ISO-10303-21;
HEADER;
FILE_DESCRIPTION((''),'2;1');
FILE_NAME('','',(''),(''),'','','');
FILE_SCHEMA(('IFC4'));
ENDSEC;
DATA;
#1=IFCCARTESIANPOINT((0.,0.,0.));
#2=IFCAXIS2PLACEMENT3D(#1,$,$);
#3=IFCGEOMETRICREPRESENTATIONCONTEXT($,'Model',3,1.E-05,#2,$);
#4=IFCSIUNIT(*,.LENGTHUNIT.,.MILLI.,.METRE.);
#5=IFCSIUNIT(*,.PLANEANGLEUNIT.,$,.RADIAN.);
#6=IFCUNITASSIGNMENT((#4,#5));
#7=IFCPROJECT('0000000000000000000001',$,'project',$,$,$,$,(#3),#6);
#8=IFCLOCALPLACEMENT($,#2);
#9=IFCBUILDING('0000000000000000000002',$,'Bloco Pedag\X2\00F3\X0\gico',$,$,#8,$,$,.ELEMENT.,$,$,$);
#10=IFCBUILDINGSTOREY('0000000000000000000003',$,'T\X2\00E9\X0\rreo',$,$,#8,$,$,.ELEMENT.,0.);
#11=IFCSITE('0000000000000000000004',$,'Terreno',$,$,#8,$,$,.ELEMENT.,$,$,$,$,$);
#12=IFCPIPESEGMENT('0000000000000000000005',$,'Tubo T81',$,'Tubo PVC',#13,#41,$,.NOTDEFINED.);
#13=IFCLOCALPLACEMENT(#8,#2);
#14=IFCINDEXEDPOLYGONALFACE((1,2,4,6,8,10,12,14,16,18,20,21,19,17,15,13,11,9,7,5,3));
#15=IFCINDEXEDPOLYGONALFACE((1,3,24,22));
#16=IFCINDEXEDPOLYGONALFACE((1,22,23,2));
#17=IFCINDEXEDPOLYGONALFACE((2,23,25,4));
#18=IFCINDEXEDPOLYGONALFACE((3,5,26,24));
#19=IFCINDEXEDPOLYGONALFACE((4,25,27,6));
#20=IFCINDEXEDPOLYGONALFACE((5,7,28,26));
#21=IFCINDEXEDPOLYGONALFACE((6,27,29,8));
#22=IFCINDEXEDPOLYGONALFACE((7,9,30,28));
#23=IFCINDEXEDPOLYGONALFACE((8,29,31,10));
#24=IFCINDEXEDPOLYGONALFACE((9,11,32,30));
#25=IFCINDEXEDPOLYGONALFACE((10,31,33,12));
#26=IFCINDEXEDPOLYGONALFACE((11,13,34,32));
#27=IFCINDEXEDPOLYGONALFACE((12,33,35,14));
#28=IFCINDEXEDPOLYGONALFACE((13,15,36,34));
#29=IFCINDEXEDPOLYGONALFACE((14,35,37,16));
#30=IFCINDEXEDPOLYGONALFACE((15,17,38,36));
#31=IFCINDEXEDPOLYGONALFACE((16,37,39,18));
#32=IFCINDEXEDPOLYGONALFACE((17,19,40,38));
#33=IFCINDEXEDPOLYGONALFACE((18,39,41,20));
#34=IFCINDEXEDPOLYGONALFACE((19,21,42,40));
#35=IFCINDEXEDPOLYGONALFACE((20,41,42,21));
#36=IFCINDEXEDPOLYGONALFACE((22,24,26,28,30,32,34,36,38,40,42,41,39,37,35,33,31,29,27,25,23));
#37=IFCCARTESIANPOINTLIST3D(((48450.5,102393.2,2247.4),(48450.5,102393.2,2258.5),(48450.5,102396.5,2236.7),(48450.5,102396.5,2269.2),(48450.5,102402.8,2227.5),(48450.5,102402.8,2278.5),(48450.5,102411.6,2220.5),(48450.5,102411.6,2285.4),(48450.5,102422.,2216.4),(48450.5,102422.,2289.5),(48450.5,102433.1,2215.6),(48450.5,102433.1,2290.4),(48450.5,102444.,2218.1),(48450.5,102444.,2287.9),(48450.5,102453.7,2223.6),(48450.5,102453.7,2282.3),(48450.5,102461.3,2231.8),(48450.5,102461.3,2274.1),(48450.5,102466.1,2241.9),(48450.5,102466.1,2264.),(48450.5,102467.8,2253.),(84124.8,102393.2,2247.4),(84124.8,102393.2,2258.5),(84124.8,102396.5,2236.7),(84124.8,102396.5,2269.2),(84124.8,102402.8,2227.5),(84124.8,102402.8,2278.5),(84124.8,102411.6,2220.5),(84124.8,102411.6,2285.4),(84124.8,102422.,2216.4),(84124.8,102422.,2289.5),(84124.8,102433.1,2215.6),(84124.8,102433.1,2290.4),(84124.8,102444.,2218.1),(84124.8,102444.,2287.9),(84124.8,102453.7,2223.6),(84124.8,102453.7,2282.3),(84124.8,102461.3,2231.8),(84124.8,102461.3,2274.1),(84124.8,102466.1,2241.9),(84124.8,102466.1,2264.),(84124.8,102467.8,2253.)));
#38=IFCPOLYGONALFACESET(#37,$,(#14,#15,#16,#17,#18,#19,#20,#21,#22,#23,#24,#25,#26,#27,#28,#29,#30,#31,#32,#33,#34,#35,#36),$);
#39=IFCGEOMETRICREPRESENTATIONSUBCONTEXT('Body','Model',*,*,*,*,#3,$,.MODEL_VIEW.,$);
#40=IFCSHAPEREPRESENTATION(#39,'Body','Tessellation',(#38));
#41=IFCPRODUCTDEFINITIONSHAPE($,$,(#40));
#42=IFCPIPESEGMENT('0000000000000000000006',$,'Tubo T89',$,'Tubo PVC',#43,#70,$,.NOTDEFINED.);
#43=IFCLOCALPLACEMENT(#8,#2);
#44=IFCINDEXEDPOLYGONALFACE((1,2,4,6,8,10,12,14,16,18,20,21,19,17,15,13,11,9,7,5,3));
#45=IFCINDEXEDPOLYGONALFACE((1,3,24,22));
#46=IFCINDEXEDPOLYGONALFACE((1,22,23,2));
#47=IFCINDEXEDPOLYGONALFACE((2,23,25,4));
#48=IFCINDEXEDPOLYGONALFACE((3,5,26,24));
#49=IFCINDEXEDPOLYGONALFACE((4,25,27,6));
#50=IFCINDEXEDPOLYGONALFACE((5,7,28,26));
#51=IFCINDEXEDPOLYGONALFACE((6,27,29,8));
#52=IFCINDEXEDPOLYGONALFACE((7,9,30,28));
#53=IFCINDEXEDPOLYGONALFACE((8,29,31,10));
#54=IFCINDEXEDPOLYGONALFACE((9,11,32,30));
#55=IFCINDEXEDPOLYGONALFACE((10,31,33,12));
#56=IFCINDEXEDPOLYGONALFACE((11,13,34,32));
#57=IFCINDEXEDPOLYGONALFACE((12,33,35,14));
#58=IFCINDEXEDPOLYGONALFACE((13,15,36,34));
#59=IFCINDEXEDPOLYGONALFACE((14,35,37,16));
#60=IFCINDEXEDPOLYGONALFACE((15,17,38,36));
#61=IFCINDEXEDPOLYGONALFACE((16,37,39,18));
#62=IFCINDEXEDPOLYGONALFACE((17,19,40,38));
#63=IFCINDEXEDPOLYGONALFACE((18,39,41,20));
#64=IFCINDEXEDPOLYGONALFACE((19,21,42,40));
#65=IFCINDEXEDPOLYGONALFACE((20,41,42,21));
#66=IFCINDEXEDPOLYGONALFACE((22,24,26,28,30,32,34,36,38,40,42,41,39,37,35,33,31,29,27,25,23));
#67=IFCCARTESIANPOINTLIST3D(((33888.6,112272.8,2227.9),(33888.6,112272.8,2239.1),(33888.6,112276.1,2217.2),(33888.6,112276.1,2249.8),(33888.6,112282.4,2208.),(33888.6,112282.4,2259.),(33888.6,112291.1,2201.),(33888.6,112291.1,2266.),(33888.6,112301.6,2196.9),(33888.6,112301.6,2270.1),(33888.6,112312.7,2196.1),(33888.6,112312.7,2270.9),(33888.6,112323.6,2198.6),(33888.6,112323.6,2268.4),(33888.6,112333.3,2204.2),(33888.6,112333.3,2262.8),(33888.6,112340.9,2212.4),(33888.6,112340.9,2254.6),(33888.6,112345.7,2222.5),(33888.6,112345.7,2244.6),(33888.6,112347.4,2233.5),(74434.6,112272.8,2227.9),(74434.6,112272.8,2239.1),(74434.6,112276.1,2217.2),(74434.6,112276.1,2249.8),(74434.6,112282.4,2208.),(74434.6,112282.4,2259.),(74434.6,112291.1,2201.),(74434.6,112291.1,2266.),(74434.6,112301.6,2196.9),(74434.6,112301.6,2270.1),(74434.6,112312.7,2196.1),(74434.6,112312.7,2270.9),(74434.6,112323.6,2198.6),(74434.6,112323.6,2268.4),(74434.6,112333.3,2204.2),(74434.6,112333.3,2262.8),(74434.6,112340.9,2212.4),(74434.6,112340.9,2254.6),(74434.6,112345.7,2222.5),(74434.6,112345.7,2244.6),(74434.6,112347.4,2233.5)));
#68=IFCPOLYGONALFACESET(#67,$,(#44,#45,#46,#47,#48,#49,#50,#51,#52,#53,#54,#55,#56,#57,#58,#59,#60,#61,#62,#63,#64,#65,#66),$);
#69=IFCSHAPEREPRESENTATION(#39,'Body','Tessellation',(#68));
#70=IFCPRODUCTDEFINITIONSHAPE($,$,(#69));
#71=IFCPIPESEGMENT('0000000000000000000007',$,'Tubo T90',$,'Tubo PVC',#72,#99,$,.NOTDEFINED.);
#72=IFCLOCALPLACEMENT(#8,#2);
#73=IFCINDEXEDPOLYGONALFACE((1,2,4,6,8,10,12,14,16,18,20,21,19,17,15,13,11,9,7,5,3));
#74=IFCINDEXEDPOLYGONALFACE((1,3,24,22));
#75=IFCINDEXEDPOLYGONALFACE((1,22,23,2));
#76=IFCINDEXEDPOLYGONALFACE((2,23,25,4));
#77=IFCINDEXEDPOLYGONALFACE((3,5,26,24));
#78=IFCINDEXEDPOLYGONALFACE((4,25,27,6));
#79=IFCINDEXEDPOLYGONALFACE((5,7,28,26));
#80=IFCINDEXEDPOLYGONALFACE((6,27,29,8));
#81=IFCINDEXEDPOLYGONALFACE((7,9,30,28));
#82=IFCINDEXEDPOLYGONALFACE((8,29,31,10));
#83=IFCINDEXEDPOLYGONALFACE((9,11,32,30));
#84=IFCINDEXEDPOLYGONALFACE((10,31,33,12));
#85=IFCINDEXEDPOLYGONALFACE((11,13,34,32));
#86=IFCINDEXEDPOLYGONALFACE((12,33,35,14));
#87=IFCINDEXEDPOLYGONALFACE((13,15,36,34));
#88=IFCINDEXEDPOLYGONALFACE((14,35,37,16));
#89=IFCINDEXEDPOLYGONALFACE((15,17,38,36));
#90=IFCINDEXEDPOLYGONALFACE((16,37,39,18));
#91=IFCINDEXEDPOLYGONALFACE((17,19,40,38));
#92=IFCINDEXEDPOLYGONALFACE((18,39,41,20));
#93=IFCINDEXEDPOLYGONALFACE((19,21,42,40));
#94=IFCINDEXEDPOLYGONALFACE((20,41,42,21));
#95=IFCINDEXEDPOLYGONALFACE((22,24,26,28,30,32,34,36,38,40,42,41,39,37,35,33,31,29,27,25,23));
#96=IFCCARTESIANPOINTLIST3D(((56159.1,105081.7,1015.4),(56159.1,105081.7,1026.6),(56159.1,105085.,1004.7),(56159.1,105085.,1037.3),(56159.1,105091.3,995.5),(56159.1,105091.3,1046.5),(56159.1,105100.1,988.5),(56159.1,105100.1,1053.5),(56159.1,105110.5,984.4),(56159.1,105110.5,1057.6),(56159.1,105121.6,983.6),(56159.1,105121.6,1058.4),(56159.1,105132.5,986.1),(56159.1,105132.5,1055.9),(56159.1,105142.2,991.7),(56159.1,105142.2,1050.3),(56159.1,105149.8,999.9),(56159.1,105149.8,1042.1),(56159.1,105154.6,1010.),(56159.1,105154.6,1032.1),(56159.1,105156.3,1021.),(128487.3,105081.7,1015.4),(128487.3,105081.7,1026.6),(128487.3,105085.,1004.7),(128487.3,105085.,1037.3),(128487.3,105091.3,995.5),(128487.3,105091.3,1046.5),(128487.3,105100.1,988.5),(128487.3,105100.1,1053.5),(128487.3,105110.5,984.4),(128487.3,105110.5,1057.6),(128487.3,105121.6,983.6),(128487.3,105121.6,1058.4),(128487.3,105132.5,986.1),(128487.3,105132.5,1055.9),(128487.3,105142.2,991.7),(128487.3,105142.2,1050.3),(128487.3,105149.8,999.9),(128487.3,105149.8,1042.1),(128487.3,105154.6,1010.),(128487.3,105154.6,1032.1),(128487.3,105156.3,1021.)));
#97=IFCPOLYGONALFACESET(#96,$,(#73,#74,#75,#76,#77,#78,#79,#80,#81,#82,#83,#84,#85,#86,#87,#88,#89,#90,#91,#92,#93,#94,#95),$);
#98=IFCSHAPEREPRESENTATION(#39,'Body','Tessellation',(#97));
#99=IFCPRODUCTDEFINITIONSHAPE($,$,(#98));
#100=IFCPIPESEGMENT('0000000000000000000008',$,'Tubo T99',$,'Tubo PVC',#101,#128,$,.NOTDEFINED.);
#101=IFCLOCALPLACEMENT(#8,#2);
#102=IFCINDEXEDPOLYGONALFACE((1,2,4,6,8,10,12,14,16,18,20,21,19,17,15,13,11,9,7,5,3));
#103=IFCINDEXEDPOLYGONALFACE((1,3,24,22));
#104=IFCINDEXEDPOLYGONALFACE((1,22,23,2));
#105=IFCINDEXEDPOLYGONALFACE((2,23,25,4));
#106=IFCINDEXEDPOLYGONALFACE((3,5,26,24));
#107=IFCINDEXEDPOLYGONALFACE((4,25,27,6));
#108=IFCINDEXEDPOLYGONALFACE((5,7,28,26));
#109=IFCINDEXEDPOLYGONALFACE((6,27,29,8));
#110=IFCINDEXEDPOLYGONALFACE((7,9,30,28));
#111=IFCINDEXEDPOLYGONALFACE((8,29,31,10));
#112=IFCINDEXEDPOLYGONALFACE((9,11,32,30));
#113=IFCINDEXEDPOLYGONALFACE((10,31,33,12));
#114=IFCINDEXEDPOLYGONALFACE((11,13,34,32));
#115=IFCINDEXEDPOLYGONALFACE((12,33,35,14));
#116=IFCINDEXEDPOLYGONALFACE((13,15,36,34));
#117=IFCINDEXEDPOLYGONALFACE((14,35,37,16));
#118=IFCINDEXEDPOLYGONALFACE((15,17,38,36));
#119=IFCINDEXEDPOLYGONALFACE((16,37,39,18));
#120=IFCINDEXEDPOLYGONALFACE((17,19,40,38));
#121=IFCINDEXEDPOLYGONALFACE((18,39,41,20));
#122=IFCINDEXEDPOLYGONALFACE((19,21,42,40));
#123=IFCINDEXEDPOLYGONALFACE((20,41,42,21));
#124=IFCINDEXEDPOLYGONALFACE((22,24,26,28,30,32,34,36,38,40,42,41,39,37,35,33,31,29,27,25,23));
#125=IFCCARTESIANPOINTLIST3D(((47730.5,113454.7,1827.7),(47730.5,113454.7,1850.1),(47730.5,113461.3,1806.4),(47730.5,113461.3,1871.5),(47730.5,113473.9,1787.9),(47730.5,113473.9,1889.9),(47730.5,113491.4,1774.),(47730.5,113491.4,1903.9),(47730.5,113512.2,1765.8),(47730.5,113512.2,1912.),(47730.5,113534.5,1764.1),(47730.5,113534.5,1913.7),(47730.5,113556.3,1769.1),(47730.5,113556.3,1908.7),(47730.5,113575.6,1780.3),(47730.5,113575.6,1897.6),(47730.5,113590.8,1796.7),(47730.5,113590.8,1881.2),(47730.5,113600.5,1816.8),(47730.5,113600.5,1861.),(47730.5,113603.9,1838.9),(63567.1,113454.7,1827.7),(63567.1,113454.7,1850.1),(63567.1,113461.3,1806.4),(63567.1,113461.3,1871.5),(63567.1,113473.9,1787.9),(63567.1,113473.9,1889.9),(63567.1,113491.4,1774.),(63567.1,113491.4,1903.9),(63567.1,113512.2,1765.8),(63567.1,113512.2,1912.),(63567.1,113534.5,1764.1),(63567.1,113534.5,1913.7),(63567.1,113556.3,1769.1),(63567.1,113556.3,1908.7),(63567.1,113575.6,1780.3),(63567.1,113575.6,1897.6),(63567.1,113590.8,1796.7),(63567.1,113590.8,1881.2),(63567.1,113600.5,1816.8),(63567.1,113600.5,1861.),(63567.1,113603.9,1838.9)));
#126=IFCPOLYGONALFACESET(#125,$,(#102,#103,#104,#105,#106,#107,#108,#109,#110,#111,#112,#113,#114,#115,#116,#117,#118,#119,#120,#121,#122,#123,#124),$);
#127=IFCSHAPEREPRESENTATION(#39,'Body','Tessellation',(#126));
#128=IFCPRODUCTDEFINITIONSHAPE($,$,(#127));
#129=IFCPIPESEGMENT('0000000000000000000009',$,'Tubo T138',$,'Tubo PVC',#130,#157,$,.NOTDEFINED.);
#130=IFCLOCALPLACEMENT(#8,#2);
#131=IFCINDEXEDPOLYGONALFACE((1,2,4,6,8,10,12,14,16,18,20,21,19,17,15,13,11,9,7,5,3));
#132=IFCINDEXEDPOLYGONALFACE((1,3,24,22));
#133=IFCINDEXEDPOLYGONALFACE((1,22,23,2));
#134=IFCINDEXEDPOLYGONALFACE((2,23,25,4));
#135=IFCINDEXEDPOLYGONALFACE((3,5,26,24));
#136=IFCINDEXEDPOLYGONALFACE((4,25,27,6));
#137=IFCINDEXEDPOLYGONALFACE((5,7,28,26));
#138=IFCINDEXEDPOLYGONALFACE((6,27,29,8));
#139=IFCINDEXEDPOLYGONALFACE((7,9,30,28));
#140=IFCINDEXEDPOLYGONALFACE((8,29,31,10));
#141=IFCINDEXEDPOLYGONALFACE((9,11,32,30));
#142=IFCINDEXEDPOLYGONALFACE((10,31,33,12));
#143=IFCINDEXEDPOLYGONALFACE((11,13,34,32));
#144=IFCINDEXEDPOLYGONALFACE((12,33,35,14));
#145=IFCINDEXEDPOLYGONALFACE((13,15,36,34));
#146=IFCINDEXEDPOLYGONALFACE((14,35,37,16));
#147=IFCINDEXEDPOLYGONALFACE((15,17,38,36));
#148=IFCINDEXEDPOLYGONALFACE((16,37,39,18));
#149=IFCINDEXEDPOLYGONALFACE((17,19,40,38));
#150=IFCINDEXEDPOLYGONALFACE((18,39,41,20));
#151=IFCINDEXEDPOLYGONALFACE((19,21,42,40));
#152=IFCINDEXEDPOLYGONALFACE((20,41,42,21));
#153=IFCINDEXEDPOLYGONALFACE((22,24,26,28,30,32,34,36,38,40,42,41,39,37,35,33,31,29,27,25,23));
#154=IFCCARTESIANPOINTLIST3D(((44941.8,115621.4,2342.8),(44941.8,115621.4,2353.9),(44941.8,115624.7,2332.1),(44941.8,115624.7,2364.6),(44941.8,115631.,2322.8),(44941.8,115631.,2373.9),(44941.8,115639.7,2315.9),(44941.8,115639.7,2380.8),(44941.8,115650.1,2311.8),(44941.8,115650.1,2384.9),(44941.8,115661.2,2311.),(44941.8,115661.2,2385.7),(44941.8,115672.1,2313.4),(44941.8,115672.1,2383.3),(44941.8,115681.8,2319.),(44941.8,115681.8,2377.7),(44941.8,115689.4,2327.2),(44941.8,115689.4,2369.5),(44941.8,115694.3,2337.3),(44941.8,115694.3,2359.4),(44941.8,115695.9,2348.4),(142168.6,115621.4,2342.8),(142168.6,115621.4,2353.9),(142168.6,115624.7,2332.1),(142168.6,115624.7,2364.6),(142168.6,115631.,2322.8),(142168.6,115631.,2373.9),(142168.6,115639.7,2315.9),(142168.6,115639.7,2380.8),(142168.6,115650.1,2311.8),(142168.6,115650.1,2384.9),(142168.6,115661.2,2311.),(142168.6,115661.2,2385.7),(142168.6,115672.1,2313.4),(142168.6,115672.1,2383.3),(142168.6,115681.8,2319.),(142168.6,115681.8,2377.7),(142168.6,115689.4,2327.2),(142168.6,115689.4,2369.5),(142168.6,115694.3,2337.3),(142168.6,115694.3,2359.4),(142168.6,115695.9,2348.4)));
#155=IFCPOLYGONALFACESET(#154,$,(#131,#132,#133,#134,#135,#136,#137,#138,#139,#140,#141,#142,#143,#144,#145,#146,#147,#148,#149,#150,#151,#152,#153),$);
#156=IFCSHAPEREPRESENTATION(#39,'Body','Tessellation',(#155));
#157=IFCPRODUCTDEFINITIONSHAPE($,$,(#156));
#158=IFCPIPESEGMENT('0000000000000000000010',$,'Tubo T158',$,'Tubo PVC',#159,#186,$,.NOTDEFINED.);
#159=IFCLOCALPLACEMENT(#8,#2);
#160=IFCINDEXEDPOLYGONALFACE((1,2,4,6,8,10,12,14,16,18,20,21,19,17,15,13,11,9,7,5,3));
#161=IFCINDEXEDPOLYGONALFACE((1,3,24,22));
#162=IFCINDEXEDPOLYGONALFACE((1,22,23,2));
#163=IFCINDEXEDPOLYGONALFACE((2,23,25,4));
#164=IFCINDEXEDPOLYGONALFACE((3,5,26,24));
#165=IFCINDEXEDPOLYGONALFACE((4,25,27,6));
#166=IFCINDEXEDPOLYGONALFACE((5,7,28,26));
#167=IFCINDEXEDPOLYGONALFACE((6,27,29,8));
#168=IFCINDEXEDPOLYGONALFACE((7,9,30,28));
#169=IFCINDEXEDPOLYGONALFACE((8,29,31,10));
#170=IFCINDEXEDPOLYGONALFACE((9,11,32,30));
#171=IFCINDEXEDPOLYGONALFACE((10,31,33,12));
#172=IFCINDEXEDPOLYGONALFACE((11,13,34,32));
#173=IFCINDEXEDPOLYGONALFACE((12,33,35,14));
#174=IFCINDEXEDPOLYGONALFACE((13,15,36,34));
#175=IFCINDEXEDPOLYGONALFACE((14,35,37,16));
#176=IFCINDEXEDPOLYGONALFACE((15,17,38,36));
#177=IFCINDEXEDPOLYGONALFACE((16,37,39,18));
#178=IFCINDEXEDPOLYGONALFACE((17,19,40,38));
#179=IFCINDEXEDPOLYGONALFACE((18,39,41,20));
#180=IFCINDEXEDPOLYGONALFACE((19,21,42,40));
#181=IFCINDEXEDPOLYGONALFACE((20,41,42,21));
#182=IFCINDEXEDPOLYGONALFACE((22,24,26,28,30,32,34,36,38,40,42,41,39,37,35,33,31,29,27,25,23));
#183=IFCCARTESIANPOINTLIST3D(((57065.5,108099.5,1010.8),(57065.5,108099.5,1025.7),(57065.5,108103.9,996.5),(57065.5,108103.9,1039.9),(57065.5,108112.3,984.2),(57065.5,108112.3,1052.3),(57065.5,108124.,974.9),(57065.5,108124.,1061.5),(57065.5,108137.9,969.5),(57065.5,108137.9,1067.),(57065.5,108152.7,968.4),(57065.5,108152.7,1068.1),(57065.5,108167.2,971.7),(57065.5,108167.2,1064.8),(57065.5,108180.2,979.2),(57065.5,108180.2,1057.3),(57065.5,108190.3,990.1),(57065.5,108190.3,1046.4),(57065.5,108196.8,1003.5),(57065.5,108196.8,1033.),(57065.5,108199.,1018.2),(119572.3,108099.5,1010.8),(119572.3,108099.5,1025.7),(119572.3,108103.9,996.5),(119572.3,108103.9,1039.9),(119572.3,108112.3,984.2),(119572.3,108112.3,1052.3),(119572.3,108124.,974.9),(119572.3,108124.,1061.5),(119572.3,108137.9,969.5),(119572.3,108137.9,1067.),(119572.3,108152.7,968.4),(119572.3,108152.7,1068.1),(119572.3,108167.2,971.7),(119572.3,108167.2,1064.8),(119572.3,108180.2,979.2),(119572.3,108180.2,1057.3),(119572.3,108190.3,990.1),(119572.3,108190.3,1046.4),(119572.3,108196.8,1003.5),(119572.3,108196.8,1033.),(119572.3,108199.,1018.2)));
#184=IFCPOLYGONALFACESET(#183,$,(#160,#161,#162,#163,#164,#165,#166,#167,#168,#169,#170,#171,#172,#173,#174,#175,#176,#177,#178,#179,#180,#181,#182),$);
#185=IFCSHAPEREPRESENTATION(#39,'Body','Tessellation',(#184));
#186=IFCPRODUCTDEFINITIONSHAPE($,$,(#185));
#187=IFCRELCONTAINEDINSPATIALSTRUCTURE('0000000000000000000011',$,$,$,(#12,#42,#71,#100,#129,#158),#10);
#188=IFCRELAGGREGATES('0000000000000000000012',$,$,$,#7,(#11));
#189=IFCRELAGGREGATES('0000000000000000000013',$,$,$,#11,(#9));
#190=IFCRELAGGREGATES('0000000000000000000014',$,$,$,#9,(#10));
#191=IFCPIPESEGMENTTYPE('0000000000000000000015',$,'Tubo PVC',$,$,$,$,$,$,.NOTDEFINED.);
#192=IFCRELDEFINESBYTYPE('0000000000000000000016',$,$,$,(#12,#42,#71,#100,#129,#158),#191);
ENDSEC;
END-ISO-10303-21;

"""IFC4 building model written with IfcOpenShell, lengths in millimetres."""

from ifc_helpers import new_model, si_unit, frame, origin, origin_2d, place, context, subcontext, project, spatial, circle, extrude, type_object, element, save


model = new_model("IFC4")

# Units and contexts
model_context = context("Model", 3, precision=1e-05, world=origin())
body_context = subcontext(model_context, "Body", "Model", "MODEL_VIEW")
ifc_project = project(units=[si_unit("LENGTHUNIT", "METRE", prefix="MILLI"), si_unit("PLANEANGLEUNIT", "RADIAN")], contexts=[model_context])

# Site, building, storey
placement = place(None, origin())
site = spatial("IfcSite", under=ifc_project, at=placement, Name="Terreno", CompositionType="ELEMENT")
building = spatial("IfcBuilding", under=site, at=placement, Name="Bloco Pedagógico", CompositionType="ELEMENT")
storey = spatial("IfcBuildingStorey", under=building, at=placement, Name="Térreo", CompositionType="ELEMENT", Elevation=0.0)

# Pipe segments
pipe_segment_type = type_object("IfcPipeSegmentType", Name="Tubo PVC", PredefinedType="NOTDEFINED")
pipe_segment_1_placement = place(None, frame((48450.5, 102430.3, 2253.0), z_axis=(1.0, 0.0, 0.0), x_axis=(0.0, 1.0, 0.0)))
element("IfcPipeSegment", 1, at=pipe_segment_1_placement, inside=storey, type_object=pipe_segment_type, Name="Tubo T81", ObjectType="Tubo PVC", PredefinedType="NOTDEFINED", context=body_context, shape_type="SweptSolid", body=[
    extrude(circle(Radius=37.5, at=origin_2d()), None, (0.0, 0.0, 1.0), 35674.3),
])
pipe_segment_2_placement = place(None, frame((33888.6, 112309.9, 2233.5), z_axis=(1.0, 0.0, 0.0), x_axis=(0.0, 1.0, 0.0)))
element("IfcPipeSegment", 2, at=pipe_segment_2_placement, inside=storey, type_object=pipe_segment_type, Name="Tubo T89", ObjectType="Tubo PVC", PredefinedType="NOTDEFINED", context=body_context, shape_type="SweptSolid", body=[
    extrude(circle(Radius=37.5, at=origin_2d()), None, (0.0, 0.0, 1.0), 40546.0),
])
pipe_segment_3_placement = place(None, frame((56159.1, 105118.8, 1021.0), z_axis=(1.0, 0.0, 0.0), x_axis=(0.0, 1.0, 0.0)))
element("IfcPipeSegment", 3, at=pipe_segment_3_placement, inside=storey, type_object=pipe_segment_type, Name="Tubo T90", ObjectType="Tubo PVC", PredefinedType="NOTDEFINED", context=body_context, shape_type="SweptSolid", body=[
    extrude(circle(Radius=37.5, at=origin_2d()), None, (0.0, 0.0, 1.0), 72328.2),
])
pipe_segment_4_placement = place(None, frame((47730.5, 113528.9, 1838.9), z_axis=(1.0, 0.0, 0.0), x_axis=(0.0, 1.0, 0.0)))
element("IfcPipeSegment", 4, at=pipe_segment_4_placement, inside=storey, type_object=pipe_segment_type, Name="Tubo T99", ObjectType="Tubo PVC", PredefinedType="NOTDEFINED", context=body_context, shape_type="SweptSolid", body=[
    extrude(circle(Radius=75.0, at=origin_2d()), None, (0.0, 0.0, 1.0), 15836.6),
])
pipe_segment_5_placement = place(None, frame((44941.8, 115658.4, 2348.4), z_axis=(1.0, 0.0, 0.0), x_axis=(0.0, 1.0, 0.0)))
element("IfcPipeSegment", 5, at=pipe_segment_5_placement, inside=storey, type_object=pipe_segment_type, Name="Tubo T138", ObjectType="Tubo PVC", PredefinedType="NOTDEFINED", context=body_context, shape_type="SweptSolid", body=[
    extrude(circle(Radius=37.5, at=origin_2d()), None, (0.0, 0.0, 1.0), 97226.8),
])
pipe_segment_6_placement = place(None, frame((57065.5, 108149.0, 1018.2), z_axis=(1.0, 0.0, 0.0), x_axis=(0.0, 1.0, 0.0)))
element("IfcPipeSegment", 6, at=pipe_segment_6_placement, inside=storey, type_object=pipe_segment_type, Name="Tubo T158", ObjectType="Tubo PVC", PredefinedType="NOTDEFINED", context=body_context, shape_type="SweptSolid", body=[
    extrude(circle(Radius=50.0, at=origin_2d()), None, (0.0, 0.0, 1.0), 62506.9),
])

save(model, "model.ifc")
